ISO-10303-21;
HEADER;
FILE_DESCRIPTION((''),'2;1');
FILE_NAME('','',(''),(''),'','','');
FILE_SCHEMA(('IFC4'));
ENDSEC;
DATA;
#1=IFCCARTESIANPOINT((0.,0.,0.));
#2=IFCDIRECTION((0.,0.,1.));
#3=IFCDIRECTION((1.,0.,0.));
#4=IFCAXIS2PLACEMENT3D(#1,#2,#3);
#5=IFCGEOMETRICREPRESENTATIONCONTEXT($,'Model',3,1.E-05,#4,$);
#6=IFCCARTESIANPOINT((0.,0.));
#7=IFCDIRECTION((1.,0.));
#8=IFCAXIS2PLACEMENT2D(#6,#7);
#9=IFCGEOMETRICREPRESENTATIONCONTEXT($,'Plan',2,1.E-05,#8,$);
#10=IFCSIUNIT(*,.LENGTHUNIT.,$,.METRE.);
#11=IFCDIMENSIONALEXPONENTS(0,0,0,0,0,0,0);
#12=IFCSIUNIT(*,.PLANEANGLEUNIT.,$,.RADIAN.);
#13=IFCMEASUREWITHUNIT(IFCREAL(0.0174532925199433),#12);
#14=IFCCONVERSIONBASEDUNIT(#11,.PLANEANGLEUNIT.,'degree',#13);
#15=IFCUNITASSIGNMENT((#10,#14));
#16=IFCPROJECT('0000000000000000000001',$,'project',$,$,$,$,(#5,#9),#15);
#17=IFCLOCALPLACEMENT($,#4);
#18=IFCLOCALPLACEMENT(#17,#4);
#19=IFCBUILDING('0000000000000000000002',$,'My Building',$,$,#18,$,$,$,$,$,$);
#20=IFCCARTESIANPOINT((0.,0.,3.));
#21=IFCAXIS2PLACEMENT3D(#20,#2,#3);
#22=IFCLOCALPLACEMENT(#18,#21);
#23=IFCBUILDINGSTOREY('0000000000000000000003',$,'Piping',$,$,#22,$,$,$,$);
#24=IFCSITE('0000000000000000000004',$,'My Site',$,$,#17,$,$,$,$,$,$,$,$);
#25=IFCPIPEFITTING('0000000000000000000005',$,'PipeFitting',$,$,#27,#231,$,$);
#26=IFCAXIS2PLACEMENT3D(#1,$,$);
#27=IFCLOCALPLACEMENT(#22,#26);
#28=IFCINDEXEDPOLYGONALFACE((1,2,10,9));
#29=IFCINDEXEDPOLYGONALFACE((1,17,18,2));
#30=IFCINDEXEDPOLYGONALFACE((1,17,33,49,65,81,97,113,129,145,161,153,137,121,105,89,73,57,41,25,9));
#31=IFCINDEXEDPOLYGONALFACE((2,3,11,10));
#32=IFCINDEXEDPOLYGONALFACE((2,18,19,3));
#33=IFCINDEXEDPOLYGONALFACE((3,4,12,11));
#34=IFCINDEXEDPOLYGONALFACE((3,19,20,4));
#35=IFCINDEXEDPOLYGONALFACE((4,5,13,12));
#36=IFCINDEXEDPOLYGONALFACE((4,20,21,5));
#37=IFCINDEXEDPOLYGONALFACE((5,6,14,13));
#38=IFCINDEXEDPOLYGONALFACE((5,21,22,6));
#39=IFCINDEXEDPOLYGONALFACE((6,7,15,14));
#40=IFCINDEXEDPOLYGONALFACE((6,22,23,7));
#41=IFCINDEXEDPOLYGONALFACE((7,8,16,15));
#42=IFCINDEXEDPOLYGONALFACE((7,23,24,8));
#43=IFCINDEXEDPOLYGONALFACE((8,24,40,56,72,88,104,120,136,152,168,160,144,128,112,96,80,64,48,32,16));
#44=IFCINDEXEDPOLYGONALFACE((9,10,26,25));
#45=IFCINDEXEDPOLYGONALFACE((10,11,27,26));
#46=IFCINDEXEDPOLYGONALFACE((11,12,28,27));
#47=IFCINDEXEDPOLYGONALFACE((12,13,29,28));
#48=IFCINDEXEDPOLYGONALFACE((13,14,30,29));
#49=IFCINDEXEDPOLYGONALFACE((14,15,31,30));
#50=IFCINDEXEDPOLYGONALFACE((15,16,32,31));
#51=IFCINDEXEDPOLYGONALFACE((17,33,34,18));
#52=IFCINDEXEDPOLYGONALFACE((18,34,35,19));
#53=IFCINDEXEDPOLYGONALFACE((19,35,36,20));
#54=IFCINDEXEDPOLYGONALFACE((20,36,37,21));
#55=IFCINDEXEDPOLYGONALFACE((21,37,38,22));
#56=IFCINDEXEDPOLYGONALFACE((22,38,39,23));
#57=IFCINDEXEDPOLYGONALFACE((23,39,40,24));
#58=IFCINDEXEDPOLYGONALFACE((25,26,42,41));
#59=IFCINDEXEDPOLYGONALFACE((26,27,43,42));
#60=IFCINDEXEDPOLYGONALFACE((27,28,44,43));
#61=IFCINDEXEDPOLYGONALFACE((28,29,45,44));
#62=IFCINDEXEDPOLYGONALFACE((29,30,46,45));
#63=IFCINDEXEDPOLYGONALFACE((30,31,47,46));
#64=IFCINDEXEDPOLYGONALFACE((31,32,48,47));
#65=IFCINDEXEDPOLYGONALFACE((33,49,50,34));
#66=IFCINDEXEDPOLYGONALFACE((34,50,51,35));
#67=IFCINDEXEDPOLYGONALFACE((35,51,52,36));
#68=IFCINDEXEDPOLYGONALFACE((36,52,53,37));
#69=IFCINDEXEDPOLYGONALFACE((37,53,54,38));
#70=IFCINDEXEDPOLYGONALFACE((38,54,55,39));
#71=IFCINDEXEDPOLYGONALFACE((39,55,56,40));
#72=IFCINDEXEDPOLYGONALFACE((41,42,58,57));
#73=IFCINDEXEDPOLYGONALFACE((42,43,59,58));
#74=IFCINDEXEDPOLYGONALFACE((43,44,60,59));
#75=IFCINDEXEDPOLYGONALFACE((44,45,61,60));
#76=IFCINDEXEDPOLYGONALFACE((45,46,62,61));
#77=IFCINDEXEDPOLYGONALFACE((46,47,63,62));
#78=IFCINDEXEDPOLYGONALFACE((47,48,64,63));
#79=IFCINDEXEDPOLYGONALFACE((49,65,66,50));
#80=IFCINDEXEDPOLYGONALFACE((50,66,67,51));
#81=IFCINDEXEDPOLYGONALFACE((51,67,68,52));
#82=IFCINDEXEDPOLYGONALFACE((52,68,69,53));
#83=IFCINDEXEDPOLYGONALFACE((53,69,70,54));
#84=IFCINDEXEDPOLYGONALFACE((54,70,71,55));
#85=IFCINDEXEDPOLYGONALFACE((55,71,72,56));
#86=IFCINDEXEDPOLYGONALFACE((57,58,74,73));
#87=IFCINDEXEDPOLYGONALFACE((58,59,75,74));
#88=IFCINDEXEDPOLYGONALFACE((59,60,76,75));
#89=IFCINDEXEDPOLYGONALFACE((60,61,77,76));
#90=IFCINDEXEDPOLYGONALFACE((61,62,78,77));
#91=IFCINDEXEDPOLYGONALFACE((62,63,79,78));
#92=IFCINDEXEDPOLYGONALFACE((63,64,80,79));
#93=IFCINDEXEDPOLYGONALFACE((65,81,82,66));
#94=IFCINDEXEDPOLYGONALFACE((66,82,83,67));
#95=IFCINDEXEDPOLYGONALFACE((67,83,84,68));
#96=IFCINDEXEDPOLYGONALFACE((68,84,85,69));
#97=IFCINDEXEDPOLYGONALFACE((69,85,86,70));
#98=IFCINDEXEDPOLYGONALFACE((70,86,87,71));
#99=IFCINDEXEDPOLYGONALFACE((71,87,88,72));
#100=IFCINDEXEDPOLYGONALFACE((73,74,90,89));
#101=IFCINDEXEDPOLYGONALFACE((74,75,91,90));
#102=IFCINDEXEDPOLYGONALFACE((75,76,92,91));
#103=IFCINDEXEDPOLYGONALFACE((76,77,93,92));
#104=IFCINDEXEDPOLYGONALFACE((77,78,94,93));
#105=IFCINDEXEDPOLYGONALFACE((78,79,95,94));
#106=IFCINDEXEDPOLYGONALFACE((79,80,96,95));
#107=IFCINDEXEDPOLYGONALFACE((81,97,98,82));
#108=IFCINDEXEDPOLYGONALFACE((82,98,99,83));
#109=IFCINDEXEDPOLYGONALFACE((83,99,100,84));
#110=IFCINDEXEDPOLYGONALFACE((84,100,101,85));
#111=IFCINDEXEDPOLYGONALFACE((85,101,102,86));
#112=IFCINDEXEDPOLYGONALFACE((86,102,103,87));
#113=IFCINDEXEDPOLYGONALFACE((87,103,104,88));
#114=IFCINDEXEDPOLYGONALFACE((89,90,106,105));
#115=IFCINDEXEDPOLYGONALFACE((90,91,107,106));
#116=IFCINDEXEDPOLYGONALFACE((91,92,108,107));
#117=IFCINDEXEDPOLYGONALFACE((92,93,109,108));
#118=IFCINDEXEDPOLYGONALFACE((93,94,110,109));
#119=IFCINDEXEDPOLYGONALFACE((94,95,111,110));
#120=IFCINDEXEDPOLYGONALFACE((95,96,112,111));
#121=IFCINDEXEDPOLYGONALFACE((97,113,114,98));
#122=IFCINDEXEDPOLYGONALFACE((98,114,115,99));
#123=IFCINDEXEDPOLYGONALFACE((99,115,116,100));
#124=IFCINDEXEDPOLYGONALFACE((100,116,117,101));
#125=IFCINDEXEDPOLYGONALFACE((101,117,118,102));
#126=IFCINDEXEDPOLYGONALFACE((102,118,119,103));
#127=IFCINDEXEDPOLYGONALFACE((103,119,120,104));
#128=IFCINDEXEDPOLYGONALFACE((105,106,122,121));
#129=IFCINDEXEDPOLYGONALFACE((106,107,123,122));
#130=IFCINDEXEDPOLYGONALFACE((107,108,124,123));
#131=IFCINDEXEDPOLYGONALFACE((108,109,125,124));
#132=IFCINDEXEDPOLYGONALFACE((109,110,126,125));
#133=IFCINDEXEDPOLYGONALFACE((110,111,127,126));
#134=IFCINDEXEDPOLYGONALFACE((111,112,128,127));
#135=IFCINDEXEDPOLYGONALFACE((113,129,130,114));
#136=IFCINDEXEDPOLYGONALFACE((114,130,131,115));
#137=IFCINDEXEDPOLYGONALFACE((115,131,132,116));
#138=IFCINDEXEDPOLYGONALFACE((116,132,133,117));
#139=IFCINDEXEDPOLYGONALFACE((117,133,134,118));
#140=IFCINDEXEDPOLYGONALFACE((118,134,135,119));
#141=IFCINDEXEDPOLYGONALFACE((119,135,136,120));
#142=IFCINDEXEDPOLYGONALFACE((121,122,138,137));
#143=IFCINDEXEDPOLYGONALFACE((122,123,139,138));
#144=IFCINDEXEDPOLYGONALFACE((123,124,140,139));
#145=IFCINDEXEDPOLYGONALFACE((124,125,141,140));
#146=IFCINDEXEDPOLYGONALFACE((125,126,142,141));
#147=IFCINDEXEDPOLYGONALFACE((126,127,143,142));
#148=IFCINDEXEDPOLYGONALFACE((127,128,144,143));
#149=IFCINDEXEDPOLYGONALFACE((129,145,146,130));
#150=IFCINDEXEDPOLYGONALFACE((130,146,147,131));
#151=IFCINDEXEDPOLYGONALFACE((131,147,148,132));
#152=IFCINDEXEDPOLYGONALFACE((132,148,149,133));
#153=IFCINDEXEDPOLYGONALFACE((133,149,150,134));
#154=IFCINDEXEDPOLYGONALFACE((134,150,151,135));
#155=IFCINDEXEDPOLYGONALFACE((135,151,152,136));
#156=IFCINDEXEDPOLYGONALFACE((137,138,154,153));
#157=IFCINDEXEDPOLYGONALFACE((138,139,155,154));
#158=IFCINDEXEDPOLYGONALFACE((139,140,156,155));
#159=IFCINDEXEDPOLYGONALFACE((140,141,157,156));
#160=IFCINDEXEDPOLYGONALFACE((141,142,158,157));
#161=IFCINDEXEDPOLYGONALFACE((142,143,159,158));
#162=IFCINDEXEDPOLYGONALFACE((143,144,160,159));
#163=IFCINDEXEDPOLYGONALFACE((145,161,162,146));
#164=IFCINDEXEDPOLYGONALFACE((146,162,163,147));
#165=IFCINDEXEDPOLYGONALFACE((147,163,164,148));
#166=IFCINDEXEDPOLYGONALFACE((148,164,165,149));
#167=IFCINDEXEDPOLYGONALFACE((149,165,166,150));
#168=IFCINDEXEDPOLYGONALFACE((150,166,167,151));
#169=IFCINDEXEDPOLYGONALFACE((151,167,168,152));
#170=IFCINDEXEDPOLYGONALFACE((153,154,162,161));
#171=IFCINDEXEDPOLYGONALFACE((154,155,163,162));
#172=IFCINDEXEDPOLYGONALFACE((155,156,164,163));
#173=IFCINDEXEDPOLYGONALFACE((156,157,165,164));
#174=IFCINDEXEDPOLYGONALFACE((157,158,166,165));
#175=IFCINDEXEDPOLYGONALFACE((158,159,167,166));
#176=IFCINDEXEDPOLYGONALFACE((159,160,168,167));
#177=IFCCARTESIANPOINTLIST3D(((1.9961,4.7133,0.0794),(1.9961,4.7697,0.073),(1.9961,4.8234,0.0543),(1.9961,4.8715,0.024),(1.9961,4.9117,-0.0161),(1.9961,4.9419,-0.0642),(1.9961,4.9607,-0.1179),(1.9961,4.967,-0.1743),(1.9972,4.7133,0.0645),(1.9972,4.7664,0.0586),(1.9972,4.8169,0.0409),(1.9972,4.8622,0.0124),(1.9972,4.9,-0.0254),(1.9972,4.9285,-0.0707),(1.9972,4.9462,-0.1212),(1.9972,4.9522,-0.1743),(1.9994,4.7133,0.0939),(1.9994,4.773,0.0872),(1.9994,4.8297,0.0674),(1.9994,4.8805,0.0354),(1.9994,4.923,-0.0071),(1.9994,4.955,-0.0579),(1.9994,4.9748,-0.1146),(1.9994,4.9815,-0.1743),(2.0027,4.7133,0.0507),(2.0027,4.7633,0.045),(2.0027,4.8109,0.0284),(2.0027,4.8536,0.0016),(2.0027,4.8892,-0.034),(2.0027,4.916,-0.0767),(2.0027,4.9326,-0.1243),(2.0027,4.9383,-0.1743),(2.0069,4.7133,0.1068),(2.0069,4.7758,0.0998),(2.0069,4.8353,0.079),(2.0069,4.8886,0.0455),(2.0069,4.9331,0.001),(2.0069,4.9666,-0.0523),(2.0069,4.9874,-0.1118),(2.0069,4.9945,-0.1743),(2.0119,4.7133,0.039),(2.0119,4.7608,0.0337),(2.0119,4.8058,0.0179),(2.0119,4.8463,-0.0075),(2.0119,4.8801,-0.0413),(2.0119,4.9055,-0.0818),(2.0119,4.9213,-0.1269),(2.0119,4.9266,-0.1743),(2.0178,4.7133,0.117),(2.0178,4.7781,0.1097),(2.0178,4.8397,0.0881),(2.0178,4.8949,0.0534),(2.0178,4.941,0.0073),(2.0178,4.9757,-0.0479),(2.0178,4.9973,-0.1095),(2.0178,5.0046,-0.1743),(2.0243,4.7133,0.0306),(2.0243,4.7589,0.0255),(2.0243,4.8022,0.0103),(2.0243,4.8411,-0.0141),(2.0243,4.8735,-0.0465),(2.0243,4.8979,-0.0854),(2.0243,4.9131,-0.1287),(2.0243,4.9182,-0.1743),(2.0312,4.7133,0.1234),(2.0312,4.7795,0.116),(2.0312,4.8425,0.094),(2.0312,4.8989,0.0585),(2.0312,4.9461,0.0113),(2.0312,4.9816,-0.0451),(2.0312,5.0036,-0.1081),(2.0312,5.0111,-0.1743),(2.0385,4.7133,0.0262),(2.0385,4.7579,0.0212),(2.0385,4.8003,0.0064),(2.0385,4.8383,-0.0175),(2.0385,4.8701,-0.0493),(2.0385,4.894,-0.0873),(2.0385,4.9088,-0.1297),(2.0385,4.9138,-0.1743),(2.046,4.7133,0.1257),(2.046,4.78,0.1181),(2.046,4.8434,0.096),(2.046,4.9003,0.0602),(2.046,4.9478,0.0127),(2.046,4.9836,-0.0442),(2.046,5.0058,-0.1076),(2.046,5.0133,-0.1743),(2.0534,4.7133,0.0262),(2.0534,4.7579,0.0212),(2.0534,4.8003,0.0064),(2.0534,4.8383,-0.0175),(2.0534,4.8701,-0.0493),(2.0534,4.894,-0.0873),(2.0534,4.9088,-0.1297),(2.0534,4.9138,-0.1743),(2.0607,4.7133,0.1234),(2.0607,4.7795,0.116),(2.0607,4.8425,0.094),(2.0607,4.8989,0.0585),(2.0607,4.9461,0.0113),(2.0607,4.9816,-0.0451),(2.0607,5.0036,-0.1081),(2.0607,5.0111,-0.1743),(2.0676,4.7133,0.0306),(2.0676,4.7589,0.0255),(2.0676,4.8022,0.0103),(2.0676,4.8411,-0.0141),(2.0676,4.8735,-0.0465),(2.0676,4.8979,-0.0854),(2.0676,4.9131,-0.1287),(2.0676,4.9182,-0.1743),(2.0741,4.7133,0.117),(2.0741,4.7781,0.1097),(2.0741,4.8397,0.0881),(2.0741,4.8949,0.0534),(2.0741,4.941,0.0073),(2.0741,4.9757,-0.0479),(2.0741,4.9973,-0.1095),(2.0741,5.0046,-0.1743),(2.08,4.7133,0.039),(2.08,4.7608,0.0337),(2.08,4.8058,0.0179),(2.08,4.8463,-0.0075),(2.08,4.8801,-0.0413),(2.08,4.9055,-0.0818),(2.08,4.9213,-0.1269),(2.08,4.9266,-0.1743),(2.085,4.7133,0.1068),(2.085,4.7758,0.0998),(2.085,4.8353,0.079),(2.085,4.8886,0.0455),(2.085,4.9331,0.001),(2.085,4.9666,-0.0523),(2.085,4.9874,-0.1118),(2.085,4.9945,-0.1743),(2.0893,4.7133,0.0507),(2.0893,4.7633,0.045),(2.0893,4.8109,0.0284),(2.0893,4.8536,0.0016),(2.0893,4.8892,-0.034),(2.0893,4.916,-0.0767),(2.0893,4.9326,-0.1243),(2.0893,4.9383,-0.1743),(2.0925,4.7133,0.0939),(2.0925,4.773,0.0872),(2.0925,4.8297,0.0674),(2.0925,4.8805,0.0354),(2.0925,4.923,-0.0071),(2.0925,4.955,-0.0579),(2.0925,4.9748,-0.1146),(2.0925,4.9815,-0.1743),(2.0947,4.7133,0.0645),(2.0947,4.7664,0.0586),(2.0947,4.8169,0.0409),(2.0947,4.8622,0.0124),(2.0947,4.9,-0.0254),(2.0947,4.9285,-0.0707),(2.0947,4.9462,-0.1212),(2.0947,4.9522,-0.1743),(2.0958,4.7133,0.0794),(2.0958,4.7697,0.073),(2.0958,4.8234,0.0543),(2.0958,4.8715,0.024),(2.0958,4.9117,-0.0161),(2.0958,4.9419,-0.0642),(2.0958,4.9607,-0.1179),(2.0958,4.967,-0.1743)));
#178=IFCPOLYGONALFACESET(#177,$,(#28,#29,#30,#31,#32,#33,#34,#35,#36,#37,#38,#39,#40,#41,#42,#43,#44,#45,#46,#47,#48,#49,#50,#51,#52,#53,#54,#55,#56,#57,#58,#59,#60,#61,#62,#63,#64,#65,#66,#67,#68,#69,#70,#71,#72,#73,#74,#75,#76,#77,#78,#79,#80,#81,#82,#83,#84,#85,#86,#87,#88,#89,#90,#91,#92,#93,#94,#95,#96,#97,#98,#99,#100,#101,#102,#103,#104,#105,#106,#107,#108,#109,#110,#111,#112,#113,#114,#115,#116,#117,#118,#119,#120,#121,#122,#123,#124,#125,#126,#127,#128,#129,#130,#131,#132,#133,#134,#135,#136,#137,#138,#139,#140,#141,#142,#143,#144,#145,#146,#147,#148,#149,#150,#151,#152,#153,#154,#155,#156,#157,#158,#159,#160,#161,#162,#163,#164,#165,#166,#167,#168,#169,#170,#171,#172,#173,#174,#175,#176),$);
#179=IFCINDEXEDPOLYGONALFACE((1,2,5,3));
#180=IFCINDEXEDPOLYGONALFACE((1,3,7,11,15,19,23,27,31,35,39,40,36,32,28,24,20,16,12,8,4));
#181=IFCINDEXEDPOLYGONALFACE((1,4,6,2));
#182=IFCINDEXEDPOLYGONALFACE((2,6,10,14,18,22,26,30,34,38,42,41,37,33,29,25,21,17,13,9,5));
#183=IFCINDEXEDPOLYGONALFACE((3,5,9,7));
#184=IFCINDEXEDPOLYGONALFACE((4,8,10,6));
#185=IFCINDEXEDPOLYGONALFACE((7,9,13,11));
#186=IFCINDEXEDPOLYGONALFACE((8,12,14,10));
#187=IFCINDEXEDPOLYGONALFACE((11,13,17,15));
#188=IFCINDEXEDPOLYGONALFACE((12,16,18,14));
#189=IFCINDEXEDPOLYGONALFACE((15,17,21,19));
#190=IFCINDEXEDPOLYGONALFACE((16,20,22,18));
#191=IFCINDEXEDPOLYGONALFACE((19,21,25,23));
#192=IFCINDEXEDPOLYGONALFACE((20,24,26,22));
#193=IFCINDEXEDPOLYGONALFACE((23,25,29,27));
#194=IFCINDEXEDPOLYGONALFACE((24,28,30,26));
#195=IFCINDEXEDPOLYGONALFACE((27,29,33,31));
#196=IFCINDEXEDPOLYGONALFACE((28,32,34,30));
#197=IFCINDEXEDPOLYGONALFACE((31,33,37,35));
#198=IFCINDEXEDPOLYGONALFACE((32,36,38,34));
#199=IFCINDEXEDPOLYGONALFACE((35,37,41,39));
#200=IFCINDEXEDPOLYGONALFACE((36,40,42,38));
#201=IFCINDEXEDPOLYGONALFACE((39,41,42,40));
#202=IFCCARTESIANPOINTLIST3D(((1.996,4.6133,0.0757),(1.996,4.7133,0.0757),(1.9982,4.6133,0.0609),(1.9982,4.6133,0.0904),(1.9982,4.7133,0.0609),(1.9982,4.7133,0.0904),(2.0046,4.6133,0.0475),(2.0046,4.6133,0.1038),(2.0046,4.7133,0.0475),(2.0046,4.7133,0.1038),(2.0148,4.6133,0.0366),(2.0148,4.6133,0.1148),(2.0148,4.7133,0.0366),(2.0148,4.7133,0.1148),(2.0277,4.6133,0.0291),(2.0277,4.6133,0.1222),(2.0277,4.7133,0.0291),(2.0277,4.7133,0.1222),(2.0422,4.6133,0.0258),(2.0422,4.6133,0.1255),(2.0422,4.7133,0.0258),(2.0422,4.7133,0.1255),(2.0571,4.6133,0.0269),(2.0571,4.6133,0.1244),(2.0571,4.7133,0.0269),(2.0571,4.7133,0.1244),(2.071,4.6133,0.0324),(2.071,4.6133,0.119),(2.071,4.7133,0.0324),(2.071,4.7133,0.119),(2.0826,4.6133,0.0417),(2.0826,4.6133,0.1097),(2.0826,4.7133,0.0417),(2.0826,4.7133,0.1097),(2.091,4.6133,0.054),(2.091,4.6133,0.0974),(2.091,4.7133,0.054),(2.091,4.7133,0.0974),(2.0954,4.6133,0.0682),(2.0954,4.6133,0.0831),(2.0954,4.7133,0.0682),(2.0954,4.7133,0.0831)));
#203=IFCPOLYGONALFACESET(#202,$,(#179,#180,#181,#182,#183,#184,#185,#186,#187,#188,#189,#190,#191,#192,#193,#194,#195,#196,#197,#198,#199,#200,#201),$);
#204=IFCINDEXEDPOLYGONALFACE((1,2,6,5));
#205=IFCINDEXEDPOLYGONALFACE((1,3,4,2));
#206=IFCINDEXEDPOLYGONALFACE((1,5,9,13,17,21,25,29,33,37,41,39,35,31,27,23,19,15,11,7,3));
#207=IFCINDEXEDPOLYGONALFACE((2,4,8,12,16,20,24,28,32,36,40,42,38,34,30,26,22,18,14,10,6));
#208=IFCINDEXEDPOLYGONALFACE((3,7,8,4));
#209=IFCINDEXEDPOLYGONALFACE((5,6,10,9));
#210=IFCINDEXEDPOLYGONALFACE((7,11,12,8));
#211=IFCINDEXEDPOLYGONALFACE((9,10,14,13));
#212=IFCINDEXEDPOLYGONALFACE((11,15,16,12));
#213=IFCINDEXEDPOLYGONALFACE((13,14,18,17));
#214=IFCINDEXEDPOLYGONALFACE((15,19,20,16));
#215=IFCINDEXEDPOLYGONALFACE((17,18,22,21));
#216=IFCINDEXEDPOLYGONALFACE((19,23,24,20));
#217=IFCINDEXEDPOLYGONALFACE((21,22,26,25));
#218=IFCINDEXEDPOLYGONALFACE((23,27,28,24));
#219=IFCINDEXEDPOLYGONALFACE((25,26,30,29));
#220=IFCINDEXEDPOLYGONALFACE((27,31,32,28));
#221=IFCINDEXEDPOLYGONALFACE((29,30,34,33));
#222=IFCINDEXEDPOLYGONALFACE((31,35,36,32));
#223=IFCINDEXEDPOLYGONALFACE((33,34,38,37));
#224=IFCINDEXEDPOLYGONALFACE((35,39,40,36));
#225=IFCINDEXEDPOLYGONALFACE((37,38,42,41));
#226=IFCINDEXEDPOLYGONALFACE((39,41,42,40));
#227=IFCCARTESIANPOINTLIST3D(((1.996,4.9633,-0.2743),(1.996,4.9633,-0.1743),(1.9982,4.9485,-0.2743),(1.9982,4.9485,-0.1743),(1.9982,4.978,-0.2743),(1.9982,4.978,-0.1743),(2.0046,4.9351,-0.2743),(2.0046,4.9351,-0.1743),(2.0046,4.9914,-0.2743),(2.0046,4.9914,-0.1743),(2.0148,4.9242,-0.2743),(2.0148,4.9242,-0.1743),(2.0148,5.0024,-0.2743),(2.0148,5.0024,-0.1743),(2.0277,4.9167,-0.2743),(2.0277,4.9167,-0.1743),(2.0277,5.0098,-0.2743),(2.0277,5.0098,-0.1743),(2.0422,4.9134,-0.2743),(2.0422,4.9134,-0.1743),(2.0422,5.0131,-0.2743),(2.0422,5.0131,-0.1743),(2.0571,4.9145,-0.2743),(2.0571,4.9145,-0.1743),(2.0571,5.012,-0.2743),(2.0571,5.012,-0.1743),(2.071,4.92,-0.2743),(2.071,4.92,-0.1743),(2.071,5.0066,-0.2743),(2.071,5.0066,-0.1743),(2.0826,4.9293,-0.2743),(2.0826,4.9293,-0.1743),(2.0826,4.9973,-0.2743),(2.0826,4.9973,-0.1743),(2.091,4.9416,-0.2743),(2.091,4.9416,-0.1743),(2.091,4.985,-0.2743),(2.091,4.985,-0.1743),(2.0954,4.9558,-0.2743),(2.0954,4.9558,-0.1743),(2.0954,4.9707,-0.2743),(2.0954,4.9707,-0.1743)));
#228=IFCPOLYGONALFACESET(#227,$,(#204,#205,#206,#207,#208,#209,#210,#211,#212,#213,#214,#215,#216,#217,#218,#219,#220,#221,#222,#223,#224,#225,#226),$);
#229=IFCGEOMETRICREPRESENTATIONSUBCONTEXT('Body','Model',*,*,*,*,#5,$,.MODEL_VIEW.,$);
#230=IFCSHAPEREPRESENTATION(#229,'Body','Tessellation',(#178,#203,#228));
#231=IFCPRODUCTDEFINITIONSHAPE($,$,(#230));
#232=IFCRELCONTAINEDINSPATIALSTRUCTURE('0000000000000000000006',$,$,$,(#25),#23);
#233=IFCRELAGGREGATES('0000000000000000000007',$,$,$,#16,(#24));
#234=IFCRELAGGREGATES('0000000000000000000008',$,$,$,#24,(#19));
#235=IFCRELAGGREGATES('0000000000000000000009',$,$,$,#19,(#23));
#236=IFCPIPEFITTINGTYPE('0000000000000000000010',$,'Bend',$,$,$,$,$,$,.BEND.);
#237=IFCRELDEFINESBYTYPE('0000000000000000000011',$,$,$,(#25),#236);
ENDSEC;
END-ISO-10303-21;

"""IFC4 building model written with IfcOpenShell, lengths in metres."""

from ifc_helpers import new_model, entity, si_unit, converted_unit, frame, origin_with_axes, origin_2d_with_axis, place, context, subcontext, project, spatial, circle, extrude, source, transform, mapped, type_object, type_shapes, element, save


model = new_model("IFC4")

# Units and contexts
model_context = context("Model", 3, precision=1e-05, world=origin_with_axes())
plan_context = context("Plan", 2, precision=1e-05, world=origin_2d_with_axis())
body_context = subcontext(model_context, "Body", "Model", "MODEL_VIEW")
ifc_project = project(units=[si_unit("LENGTHUNIT", "METRE"), converted_unit("PLANEANGLEUNIT", "degree", entity("IfcReal", 0.0174532925199433), si_unit("PLANEANGLEUNIT", "RADIAN"), dimensions=[0, 0, 0, 0, 0, 0, 0])], contexts=[model_context, plan_context])

# Site, building, storey
site_placement = place(None, origin_with_axes())
site = spatial("IfcSite", under=ifc_project, at=site_placement, Name="My Site")
building_placement = place(site_placement, origin_with_axes())
building = spatial("IfcBuilding", under=site, at=building_placement, Name="My Building")
storey_placement = place(building_placement, frame((0.0, 0.0, 3.0), z_axis=(0.0, 0.0, 1.0), x_axis=(1.0, 0.0, 0.0)))
storey = spatial("IfcBuildingStorey", under=building, at=storey_placement, Name="Piping")

# Pipe fitting
pipe_fitting_type_1 = type_object("IfcPipeFittingType", Name="Bend", PredefinedType="BEND")
shared_shape_1 = source(origin_with_axes(), body_context, "Body", "SolidModel", [
    entity("IfcSweptDiskSolid", entity("IfcIndexedPolyCurve", entity("IfcCartesianPointList3D", [[0.0, 0.0, 0.1], [0.0, -0.0732, 0.2768], [0.0, -0.25, 0.35]]), [entity("IfcArcIndex", [1, 2, 3])]), 0.05),
    extrude(circle(Radius=0.05), origin_with_axes(), (0.0, 0.0, 1.0), 0.1),
    extrude(circle(Radius=0.05), frame((0.0, -0.25, 0.35), z_axis=(0.0, -1.0, 0.0), x_axis=(1.0, 0.0, 0.0)), (0.0, 0.0, 1.0), 0.1),
])
type_shapes(pipe_fitting_type_1, [shared_shape_1])
for number, where, z_axis, x_axis, name in (
    (1, (2.046, 4.6133, 0.0757), (0.0, 1.0, 0.0), (-1.0, 0.0, 0.0), "PipeFitting"),
):
    element("IfcPipeFitting", number, at=place(storey_placement, frame(where, z_axis=z_axis, x_axis=x_axis)), inside=storey, type_object=pipe_fitting_type_1, Name=name, context=body_context, shape_type="MappedRepresentation", body=[
        mapped(shared_shape_1, transform((0.0, 0.0, 0.0), x_axis=(1.0, 0.0, 0.0), y_axis=(0.0, 1.0, 0.0), z_axis=(0.0, 0.0, 1.0), scale=1.0)),
    ])

save(model, "model.ifc")
